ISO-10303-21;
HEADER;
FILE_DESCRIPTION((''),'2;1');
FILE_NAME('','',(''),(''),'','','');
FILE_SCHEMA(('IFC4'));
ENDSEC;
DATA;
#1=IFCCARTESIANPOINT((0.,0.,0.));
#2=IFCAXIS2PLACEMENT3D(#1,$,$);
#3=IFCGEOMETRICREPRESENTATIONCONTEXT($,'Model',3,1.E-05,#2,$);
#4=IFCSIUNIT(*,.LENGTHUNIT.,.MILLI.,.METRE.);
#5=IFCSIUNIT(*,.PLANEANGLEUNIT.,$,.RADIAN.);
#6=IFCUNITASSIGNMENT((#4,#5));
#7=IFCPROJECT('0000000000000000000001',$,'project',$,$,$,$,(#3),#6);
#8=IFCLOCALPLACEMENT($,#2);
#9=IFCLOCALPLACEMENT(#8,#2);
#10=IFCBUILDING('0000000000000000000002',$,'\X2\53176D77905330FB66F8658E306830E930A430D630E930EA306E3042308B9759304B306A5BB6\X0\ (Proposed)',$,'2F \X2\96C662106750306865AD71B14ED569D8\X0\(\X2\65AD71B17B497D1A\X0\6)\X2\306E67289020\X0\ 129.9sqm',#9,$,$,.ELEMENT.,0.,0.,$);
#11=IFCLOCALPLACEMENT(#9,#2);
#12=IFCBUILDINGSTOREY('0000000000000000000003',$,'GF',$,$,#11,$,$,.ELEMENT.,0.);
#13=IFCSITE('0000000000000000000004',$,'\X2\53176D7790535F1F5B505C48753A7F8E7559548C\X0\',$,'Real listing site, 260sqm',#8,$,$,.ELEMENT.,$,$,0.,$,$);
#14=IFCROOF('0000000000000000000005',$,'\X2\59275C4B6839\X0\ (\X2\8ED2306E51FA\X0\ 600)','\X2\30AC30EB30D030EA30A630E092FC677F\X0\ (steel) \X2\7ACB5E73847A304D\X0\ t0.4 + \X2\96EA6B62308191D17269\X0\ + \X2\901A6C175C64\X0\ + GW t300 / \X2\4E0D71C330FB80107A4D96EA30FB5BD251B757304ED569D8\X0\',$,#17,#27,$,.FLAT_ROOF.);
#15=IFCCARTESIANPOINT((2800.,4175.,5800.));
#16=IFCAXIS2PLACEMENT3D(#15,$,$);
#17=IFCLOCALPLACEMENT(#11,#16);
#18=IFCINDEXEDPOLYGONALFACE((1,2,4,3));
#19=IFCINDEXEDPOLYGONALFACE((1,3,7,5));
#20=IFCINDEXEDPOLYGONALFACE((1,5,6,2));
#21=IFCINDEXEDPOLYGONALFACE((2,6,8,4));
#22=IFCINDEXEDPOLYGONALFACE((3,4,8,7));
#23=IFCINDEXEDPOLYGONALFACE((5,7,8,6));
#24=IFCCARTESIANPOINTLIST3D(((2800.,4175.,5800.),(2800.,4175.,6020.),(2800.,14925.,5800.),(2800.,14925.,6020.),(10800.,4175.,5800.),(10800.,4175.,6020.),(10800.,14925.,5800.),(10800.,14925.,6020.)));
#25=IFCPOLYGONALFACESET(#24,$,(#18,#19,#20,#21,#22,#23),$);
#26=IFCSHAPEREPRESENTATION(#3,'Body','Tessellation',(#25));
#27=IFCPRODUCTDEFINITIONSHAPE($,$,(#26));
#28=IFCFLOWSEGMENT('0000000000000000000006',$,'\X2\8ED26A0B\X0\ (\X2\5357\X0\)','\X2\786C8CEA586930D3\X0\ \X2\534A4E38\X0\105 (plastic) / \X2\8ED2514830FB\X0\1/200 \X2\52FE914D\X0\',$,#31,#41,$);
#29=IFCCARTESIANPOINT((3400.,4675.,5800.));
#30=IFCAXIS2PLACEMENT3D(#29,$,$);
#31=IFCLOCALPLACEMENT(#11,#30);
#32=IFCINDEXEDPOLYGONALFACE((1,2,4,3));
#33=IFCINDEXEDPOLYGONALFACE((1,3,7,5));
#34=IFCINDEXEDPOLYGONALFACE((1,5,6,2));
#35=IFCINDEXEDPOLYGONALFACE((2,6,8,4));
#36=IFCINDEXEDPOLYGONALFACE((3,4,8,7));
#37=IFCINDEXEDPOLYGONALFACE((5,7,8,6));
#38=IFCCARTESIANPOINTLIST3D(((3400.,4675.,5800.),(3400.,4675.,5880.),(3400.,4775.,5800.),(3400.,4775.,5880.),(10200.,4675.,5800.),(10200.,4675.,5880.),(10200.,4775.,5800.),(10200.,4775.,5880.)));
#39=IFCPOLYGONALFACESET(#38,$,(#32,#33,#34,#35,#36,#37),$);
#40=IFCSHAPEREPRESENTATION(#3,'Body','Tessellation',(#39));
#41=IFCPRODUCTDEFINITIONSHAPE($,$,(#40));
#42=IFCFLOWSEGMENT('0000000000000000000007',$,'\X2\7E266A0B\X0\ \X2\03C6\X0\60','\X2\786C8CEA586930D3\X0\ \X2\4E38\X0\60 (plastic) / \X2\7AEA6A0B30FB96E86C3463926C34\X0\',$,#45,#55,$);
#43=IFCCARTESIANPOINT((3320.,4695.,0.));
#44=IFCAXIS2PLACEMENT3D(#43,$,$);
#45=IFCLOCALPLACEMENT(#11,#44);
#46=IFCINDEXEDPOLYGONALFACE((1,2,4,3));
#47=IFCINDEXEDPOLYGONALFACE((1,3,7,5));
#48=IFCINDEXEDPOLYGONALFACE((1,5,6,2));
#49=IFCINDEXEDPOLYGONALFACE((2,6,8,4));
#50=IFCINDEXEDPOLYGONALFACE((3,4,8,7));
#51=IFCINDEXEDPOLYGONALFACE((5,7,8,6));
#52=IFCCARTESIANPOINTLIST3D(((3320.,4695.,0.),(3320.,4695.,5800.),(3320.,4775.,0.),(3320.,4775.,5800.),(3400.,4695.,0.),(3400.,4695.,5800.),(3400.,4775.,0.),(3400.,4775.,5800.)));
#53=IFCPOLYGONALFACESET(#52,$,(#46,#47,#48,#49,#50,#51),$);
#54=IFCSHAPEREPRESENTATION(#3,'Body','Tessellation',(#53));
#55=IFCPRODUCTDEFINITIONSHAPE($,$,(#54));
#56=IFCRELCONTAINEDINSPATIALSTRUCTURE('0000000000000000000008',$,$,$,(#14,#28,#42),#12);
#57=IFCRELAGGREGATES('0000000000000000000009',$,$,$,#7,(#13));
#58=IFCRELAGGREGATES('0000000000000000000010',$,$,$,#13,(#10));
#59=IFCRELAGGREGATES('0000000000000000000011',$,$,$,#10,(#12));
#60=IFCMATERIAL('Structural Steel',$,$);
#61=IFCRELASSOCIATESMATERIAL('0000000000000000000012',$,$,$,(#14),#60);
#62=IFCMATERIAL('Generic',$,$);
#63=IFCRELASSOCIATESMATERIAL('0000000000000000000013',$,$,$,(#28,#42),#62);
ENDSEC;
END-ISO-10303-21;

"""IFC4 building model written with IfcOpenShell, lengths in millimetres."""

from ifc_helpers import new_model, si_unit, frame, frame_2d, origin, place, context, project, spatial, rectangle, extrude, material, element, save


model = new_model("IFC4")

# Units and contexts
model_context = context("Model", 3, precision=1e-05, world=origin())
ifc_project = project(units=[si_unit("LENGTHUNIT", "METRE", prefix="MILLI"), si_unit("PLANEANGLEUNIT", "RADIAN")], contexts=[model_context])

# Site, building, storey
site_placement = place(None, origin())
site = spatial("IfcSite", under=ifc_project, at=site_placement, Name="北海道弟子屈町美留和", ObjectType="Real listing site, 260sqm", CompositionType="ELEMENT", RefElevation=0.0)
building_placement = place(site_placement, origin())
building = spatial("IfcBuilding", under=site, at=building_placement, Name="北海道・書斎とライブラリのある静かな家 (Proposed)", ObjectType="2F 集成材と断熱仕様(断熱等級6)の木造 129.9sqm", CompositionType="ELEMENT", ElevationOfRefHeight=0.0, ElevationOfTerrain=0.0)
storey_placement = place(building_placement, origin())
storey = spatial("IfcBuildingStorey", under=building, at=storey_placement, Name="GF", CompositionType="ELEMENT", Elevation=0.0)

# Roof
ifc_material_1 = material(Name="Structural Steel")
roof_placement = place(storey_placement, frame((2800.0, 4175.0, 5800.0)))
element("IfcRoof", 1, at=roof_placement, inside=storey, material=ifc_material_1, Name="大屋根 (軒の出 600)", Description="ガルバリウム鋼板 (steel) 立平葺き t0.4 + 雪止め金物 + 通気層 + GW t300 / 不燃・耐積雪・寒冷地仕様", PredefinedType="FLAT_ROOF", context=model_context, shape_type="SweptSolid", body=[
    extrude(rectangle(XDim=8000.0, YDim=10750.0, at=frame_2d((4000.0, 5375.0))), frame((2800.0, 4175.0, 5800.0)), (0.0, 0.0, 1.0), 220.0),
])

# Flow segments
ifc_material_2 = material(Name="Generic")
flow_segment_1_placement = place(storey_placement, frame((3400.0, 4675.0, 5800.0)))
element("IfcFlowSegment", 2, at=flow_segment_1_placement, inside=storey, material=ifc_material_2, Name="軒樋 (南)", Description="硬質塩ビ 半丸105 (plastic) / 軒先・1/200 勾配", context=model_context, shape_type="SweptSolid", body=[
    extrude(rectangle(XDim=6800.0, YDim=100.0, at=frame_2d((3400.0, 50.0))), frame((3400.0, 4675.0, 5800.0)), (0.0, 0.0, 1.0), 80.0),
])
flow_segment_2_placement = place(storey_placement, frame((3320.0, 4695.0, 0.0)))
element("IfcFlowSegment", 3, at=flow_segment_2_placement, inside=storey, material=ifc_material_2, Name="縦樋 φ60", Description="硬質塩ビ 丸60 (plastic) / 竪樋・雨水排水", context=model_context, shape_type="SweptSolid", body=[
    extrude(rectangle(XDim=80.0, YDim=80.0, at=frame_2d((40.0, 40.0))), frame((3320.0, 4695.0, 0.0)), (0.0, 0.0, 1.0), 5800.0),
])

save(model, "model.ifc")
